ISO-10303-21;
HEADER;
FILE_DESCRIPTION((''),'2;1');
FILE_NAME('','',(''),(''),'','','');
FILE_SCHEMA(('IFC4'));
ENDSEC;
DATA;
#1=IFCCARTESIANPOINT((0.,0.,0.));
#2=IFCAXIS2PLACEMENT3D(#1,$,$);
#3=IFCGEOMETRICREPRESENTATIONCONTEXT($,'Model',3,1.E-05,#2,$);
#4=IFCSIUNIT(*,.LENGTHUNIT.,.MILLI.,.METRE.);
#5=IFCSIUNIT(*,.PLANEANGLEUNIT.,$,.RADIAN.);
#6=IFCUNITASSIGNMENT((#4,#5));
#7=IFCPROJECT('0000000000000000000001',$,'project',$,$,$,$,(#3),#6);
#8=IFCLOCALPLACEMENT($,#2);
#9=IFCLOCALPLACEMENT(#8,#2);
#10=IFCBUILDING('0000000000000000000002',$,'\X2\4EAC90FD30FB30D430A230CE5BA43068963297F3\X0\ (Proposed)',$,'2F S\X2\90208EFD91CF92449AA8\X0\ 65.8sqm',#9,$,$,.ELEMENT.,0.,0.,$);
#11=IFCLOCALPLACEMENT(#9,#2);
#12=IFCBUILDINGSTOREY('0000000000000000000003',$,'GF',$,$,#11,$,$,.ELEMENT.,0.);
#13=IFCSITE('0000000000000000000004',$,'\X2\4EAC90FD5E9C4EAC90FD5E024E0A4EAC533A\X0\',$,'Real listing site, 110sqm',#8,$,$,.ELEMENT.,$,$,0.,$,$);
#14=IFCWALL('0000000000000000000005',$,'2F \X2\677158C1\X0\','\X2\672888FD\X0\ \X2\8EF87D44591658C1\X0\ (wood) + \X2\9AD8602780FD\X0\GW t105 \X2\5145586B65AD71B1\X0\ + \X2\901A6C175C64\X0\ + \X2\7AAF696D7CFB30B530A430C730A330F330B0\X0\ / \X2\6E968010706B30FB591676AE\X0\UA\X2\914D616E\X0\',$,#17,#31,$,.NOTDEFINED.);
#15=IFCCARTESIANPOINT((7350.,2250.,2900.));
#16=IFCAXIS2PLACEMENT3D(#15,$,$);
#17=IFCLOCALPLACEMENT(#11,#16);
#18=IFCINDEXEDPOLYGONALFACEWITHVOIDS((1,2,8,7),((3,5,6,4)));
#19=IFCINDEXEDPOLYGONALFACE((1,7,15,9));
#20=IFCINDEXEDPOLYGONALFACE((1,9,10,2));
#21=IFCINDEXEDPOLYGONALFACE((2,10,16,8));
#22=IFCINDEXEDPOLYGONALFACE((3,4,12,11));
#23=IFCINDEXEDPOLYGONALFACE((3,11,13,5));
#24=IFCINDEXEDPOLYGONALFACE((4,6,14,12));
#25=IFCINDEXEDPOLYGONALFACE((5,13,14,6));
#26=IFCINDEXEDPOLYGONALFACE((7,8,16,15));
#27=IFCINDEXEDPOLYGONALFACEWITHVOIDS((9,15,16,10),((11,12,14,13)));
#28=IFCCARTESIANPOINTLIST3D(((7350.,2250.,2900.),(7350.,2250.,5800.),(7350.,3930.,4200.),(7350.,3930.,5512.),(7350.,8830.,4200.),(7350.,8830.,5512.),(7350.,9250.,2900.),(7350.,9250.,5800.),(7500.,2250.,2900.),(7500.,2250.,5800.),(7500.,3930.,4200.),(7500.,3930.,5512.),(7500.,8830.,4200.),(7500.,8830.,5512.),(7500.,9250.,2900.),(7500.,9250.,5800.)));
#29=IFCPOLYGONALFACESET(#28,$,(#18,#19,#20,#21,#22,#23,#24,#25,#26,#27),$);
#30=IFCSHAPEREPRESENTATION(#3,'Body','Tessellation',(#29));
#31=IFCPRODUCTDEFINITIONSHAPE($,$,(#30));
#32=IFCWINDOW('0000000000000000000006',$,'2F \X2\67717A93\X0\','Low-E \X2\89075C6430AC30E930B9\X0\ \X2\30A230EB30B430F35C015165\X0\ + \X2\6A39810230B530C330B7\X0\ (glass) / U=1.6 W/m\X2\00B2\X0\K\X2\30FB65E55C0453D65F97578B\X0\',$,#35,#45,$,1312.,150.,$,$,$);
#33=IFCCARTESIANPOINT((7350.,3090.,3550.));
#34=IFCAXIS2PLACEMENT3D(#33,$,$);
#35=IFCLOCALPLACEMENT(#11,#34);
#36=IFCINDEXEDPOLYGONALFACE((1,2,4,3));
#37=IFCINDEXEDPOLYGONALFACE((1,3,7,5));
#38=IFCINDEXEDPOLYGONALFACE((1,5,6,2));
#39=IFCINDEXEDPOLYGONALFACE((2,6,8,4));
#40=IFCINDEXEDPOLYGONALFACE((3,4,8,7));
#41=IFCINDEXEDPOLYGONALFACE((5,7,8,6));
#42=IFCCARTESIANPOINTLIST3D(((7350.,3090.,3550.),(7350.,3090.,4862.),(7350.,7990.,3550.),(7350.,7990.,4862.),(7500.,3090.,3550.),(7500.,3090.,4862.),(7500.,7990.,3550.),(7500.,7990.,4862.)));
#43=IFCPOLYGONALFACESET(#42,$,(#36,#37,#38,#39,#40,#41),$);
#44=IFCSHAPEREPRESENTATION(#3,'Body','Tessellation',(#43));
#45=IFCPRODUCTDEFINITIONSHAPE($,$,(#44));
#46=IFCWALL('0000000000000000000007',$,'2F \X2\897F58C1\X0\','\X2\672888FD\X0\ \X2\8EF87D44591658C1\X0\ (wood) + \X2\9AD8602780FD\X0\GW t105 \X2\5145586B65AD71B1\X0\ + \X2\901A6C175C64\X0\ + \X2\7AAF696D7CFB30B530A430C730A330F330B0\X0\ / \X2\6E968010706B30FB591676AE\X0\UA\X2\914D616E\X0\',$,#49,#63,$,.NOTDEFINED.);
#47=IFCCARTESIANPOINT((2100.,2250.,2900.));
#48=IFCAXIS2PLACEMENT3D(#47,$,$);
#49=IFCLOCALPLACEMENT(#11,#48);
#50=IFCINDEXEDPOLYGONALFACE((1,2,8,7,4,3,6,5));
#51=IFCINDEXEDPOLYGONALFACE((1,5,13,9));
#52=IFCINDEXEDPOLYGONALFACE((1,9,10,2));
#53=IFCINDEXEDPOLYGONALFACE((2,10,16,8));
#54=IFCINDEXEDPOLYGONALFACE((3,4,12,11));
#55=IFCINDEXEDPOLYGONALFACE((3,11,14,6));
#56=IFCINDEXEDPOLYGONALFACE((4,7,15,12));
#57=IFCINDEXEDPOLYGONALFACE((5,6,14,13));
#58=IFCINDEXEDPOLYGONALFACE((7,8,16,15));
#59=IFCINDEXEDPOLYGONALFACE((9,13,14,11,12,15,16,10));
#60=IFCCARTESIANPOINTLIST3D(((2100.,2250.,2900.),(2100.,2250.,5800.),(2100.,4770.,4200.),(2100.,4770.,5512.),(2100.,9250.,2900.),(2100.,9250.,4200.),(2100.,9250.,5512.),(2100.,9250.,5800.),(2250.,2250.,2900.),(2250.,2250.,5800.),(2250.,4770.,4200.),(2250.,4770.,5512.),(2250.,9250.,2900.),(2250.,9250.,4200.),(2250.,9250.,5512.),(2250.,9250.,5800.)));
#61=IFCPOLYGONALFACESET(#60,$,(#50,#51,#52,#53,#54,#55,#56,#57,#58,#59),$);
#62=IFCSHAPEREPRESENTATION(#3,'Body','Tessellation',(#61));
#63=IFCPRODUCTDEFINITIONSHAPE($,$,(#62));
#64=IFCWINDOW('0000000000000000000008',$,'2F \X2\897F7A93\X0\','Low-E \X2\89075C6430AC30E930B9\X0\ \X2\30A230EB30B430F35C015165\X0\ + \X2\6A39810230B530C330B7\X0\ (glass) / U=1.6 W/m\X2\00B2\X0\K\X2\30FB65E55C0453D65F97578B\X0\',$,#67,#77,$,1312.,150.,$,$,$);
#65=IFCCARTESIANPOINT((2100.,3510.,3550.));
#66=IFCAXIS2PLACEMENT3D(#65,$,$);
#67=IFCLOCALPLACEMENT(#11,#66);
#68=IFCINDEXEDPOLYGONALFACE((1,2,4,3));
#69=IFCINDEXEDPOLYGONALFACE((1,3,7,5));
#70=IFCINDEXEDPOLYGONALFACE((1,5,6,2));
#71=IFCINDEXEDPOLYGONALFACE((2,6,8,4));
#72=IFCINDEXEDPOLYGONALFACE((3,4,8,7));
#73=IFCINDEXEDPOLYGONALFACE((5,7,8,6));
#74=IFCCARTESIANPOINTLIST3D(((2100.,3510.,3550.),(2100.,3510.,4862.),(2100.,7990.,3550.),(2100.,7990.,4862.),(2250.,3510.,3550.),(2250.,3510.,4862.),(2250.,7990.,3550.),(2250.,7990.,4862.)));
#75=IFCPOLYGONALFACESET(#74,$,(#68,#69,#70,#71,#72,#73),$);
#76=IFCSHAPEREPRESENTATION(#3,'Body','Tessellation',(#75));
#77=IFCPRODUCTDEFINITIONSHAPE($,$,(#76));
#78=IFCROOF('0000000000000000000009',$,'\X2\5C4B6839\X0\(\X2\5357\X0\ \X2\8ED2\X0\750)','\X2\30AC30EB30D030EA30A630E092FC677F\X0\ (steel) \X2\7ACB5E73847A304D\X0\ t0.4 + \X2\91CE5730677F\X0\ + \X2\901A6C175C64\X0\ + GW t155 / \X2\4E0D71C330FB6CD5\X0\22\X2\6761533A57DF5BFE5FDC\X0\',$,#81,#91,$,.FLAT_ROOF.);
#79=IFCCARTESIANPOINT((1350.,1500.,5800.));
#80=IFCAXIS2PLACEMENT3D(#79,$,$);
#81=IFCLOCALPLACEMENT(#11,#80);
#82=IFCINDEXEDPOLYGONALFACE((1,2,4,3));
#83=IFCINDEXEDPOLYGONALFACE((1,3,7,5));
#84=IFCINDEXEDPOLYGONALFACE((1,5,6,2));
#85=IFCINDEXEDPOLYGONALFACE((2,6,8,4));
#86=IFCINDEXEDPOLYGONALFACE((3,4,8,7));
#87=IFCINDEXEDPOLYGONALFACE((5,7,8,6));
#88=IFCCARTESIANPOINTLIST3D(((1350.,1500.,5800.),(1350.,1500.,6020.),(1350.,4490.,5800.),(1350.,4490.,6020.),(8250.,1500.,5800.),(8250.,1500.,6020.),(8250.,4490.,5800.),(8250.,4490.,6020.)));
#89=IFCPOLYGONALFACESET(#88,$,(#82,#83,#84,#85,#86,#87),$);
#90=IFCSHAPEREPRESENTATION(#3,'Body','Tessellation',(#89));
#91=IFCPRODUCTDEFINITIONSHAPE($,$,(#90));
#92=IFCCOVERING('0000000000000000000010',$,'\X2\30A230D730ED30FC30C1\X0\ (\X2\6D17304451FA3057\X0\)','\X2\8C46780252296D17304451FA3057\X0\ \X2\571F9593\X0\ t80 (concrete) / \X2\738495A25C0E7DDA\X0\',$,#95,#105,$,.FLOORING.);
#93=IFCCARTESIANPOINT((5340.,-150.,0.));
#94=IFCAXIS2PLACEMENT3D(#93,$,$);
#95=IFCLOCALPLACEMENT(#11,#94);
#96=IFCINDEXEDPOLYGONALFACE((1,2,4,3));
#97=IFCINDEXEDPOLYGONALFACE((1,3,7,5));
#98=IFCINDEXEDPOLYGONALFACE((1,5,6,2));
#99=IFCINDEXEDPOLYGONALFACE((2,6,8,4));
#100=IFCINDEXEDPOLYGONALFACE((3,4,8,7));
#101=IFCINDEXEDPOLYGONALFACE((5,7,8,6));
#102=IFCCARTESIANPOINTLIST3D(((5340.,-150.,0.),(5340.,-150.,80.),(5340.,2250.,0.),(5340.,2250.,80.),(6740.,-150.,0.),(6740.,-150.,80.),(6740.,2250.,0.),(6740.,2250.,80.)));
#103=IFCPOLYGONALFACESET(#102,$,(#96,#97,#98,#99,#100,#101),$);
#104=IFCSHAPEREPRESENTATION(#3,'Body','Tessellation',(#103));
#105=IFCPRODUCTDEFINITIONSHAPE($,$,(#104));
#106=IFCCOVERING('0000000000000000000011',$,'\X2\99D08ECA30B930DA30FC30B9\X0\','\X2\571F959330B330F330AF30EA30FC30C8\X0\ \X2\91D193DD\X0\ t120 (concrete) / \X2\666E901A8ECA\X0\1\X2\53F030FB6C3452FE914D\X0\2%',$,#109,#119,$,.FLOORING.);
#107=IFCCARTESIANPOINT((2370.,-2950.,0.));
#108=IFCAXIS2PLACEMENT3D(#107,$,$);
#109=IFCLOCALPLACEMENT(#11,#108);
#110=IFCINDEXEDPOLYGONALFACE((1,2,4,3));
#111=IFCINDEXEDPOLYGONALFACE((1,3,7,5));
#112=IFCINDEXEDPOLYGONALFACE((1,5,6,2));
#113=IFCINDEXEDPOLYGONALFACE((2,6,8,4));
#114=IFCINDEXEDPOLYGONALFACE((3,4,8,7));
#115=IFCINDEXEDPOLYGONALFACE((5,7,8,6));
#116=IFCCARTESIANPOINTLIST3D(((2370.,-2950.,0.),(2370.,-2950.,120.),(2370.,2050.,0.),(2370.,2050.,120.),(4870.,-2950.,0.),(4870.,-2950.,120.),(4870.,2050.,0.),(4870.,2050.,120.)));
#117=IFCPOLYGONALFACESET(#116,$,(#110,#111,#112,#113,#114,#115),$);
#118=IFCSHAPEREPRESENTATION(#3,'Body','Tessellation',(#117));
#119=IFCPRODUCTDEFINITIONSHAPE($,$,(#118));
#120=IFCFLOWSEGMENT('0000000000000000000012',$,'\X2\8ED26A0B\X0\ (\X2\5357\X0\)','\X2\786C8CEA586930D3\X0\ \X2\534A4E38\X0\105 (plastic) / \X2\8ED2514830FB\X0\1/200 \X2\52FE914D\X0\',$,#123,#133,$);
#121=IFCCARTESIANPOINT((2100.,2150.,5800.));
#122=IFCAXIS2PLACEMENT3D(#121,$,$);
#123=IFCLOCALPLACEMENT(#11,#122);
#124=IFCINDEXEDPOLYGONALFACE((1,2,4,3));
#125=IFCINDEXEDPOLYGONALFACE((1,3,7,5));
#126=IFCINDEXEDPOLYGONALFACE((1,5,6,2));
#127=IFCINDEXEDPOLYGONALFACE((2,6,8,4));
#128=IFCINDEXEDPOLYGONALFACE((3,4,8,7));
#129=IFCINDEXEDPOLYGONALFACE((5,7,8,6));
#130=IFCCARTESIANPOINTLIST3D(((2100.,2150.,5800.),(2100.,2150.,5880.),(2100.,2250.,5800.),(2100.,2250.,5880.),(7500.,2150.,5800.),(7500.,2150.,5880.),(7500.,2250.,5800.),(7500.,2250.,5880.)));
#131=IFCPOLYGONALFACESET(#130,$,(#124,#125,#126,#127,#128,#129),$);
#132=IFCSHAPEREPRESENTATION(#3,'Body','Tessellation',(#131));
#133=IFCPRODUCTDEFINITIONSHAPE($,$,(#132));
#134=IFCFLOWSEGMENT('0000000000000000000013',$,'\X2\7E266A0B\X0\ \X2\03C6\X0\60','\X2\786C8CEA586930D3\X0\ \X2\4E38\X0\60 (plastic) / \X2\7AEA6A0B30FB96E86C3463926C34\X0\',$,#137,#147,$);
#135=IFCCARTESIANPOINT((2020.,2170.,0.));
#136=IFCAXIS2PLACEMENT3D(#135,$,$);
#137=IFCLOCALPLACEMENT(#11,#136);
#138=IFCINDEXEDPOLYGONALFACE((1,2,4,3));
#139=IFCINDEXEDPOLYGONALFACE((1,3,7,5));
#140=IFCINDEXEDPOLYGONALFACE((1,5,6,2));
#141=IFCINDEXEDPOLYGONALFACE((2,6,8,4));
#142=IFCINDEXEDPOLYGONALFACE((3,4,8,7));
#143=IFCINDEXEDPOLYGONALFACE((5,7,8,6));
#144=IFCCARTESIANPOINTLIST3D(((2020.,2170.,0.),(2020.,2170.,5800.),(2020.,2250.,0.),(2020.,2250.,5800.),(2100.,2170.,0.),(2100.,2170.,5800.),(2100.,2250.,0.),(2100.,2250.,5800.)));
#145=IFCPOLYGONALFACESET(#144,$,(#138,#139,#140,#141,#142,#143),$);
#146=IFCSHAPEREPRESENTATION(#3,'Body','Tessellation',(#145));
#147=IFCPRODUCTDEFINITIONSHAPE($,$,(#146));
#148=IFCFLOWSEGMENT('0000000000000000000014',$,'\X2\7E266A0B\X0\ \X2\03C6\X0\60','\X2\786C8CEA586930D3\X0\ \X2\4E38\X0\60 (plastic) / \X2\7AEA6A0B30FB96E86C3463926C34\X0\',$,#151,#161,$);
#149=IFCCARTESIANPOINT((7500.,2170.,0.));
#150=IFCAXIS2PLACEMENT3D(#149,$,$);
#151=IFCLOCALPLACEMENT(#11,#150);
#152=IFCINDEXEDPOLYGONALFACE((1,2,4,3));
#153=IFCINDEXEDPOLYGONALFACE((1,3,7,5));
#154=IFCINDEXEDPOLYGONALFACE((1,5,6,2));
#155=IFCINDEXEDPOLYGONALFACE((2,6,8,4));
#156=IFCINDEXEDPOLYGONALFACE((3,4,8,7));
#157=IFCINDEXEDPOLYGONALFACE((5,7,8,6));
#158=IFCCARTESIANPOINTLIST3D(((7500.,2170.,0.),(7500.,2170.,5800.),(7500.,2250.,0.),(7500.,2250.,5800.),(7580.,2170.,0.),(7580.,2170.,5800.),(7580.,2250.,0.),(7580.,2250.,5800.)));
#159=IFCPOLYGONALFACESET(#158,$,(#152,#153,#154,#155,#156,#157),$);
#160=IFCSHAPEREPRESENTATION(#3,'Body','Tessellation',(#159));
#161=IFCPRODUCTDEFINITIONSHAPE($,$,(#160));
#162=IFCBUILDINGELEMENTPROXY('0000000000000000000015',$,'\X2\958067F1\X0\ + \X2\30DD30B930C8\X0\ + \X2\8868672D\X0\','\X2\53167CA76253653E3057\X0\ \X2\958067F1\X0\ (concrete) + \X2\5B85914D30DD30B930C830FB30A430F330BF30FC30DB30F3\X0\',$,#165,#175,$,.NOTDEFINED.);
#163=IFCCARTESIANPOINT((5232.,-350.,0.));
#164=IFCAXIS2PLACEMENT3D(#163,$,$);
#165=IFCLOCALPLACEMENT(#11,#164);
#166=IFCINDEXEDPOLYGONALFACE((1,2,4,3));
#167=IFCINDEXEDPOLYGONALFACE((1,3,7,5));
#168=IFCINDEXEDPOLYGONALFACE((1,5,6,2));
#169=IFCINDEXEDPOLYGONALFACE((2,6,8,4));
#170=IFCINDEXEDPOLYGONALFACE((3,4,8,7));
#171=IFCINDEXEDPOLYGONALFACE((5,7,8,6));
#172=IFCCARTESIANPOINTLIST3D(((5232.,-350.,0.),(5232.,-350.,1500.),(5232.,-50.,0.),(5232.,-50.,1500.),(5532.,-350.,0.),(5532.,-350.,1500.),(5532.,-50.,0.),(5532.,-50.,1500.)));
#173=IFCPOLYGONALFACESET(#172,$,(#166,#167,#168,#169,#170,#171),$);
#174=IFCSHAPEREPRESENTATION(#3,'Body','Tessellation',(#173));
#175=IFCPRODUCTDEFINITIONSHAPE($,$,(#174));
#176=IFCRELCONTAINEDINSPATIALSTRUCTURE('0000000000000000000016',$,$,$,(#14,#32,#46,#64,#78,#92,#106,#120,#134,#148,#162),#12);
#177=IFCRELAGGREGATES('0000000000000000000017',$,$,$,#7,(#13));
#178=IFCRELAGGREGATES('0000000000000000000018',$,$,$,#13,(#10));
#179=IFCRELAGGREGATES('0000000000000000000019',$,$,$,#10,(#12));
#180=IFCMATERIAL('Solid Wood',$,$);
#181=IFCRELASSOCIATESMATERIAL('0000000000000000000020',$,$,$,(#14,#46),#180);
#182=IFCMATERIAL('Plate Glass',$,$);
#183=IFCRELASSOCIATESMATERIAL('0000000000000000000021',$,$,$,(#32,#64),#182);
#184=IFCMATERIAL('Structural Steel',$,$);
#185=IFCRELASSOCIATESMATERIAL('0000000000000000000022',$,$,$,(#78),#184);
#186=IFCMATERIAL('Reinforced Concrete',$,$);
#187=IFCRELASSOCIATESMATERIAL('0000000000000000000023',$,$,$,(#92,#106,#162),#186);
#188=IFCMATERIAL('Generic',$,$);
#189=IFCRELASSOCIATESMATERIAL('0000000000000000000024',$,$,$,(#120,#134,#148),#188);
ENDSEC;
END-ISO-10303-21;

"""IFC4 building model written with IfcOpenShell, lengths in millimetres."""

from ifc_helpers import new_model, si_unit, frame, frame_2d, origin, place, context, project, spatial, rectangle, extrude, material, element, fill, save


model = new_model("IFC4")

# Units and contexts
model_context = context("Model", 3, precision=1e-05, world=origin())
ifc_project = project(units=[si_unit("LENGTHUNIT", "METRE", prefix="MILLI"), si_unit("PLANEANGLEUNIT", "RADIAN")], contexts=[model_context])

# Site, building, storey
site_placement = place(None, origin())
site = spatial("IfcSite", under=ifc_project, at=site_placement, Name="京都府京都市上京区", ObjectType="Real listing site, 110sqm", CompositionType="ELEMENT", RefElevation=0.0)
building_placement = place(site_placement, origin())
building = spatial("IfcBuilding", under=site, at=building_placement, Name="京都・ピアノ室と防音 (Proposed)", ObjectType="2F S造軽量鉄骨 65.8sqm", CompositionType="ELEMENT", ElevationOfRefHeight=0.0, ElevationOfTerrain=0.0)
storey_placement = place(building_placement, origin())
storey = spatial("IfcBuildingStorey", under=building, at=storey_placement, Name="GF", CompositionType="ELEMENT", Elevation=0.0)

# Shared definitions
ifc_material_1 = material(Name="Solid Wood")

# Shared definitions
ifc_material_2 = material(Name="Reinforced Concrete")

# Shared definitions
ifc_material_3 = material(Name="Plate Glass")

# Walls, openings, windows
wall_1_placement = place(storey_placement, frame((7350.0, 2250.0, 2900.0)))
wall_1 = element("IfcWall", 1, at=wall_1_placement, inside=storey, material=ifc_material_1, Name="2F 東壁", Description="木製 軸組外壁 (wood) + 高性能GW t105 充填断熱 + 通気層 + 窯業系サイディング / 準耐火・外皮UA配慮", PredefinedType="NOTDEFINED", context=model_context, shape_type="SweptSolid", body=[
    extrude(rectangle(XDim=150.0, YDim=7000.0, at=frame_2d((75.0, 3500.0))), frame((7350.0, 2250.0, 2900.0)), (0.0, 0.0, 1.0), 2900.0),
])
opening_1_placement = place(storey_placement, frame((7350.0, 3090.0, 3550.0)))
opening_1 = element("IfcOpeningElement", 2, at=opening_1_placement, cuts=wall_1, PredefinedType="NOTDEFINED", context=model_context, shape_type="SweptSolid", body=[
    extrude(rectangle(XDim=150.0, YDim=4900.0, at=frame_2d((75.0, 2450.0))), frame((7350.0, 3090.0, 3550.0)), (0.0, 0.0, 1.0), 1312.0),
])
window_1_placement = place(storey_placement, frame((7350.0, 3090.0, 3550.0)))
window_1 = element("IfcWindow", 3, at=window_1_placement, inside=storey, material=ifc_material_3, Name="2F 東窓", Description="Low-E 複層ガラス アルゴン封入 + 樹脂サッシ (glass) / U=1.6 W/m²K・日射取得型", OverallHeight=1312.0, OverallWidth=150.0, context=model_context, shape_type="SweptSolid", body=[
    extrude(rectangle(XDim=150.0, YDim=4900.0, at=frame_2d((75.0, 2450.0))), frame((7350.0, 3090.0, 3550.0)), (0.0, 0.0, 1.0), 1312.0),
])
fill(opening_1, window_1)
wall_2_placement = place(storey_placement, frame((2100.0, 2250.0, 2900.0)))
wall_2 = element("IfcWall", 4, at=wall_2_placement, inside=storey, material=ifc_material_1, Name="2F 西壁", Description="木製 軸組外壁 (wood) + 高性能GW t105 充填断熱 + 通気層 + 窯業系サイディング / 準耐火・外皮UA配慮", PredefinedType="NOTDEFINED", context=model_context, shape_type="SweptSolid", body=[
    extrude(rectangle(XDim=150.0, YDim=7000.0, at=frame_2d((75.0, 3500.0))), frame((2100.0, 2250.0, 2900.0)), (0.0, 0.0, 1.0), 2900.0),
])
opening_2_placement = place(storey_placement, frame((2100.0, 3510.0, 3550.0)))
opening_2 = element("IfcOpeningElement", 5, at=opening_2_placement, cuts=wall_2, PredefinedType="NOTDEFINED", context=model_context, shape_type="SweptSolid", body=[
    extrude(rectangle(XDim=150.0, YDim=4480.0, at=frame_2d((75.0, 2240.0))), frame((2100.0, 3510.0, 3550.0)), (0.0, 0.0, 1.0), 1312.0),
])
window_2_placement = place(storey_placement, frame((2100.0, 3510.0, 3550.0)))
window_2 = element("IfcWindow", 6, at=window_2_placement, inside=storey, material=ifc_material_3, Name="2F 西窓", Description="Low-E 複層ガラス アルゴン封入 + 樹脂サッシ (glass) / U=1.6 W/m²K・日射取得型", OverallHeight=1312.0, OverallWidth=150.0, context=model_context, shape_type="SweptSolid", body=[
    extrude(rectangle(XDim=150.0, YDim=4480.0, at=frame_2d((75.0, 2240.0))), frame((2100.0, 3510.0, 3550.0)), (0.0, 0.0, 1.0), 1312.0),
])
fill(opening_2, window_2)

# Roof
ifc_material_4 = material(Name="Structural Steel")
for number, where, name in (
    (7, (1350.0, 1500.0, 5800.0), "屋根(南 軒750)"),
):
    element("IfcRoof", number, at=place(storey_placement, frame(where)), inside=storey, material=ifc_material_4, Name=name, Description="ガルバリウム鋼板 (steel) 立平葺き t0.4 + 野地板 + 通気層 + GW t155 / 不燃・法22条区域対応", PredefinedType="FLAT_ROOF", context=model_context, shape_type="SweptSolid", body=[
        extrude(rectangle(XDim=6900.0, YDim=2990.0, at=frame_2d((3450.0, 1495.0))), frame((1350.0, 1500.0, 5800.0)), (0.0, 0.0, 1.0), 220.0),
    ])

# Coverings
covering_1_placement = place(storey_placement, frame((5340.0, -150.0, 0.0)))
element("IfcCovering", 8, at=covering_1_placement, inside=storey, material=ifc_material_2, Name="アプローチ (洗い出し)", Description="豆砂利洗い出し 土間 t80 (concrete) / 玄関導線", PredefinedType="FLOORING", context=model_context, shape_type="SweptSolid", body=[
    extrude(rectangle(XDim=1400.0, YDim=2400.0, at=frame_2d((700.0, 1200.0))), frame((5340.0, -150.0, 0.0)), (0.0, 0.0, 1.0), 80.0),
])
covering_2_placement = place(storey_placement, frame((2370.0, -2950.0, 0.0)))
element("IfcCovering", 9, at=covering_2_placement, inside=storey, material=ifc_material_2, Name="駐車スペース", Description="土間コンクリート 金鏝 t120 (concrete) / 普通車1台・水勾配2%", PredefinedType="FLOORING", context=model_context, shape_type="SweptSolid", body=[
    extrude(rectangle(XDim=2500.0, YDim=5000.0, at=frame_2d((1250.0, 2500.0))), frame((2370.0, -2950.0, 0.0)), (0.0, 0.0, 1.0), 120.0),
])

# Flow segments
ifc_material_5 = material(Name="Generic")
flow_segment_1_placement = place(storey_placement, frame((2100.0, 2150.0, 5800.0)))
element("IfcFlowSegment", 10, at=flow_segment_1_placement, inside=storey, material=ifc_material_5, Name="軒樋 (南)", Description="硬質塩ビ 半丸105 (plastic) / 軒先・1/200 勾配", context=model_context, shape_type="SweptSolid", body=[
    extrude(rectangle(XDim=5400.0, YDim=100.0, at=frame_2d((2700.0, 50.0))), frame((2100.0, 2150.0, 5800.0)), (0.0, 0.0, 1.0), 80.0),
])
flow_segment_2_placement = place(storey_placement, frame((2020.0, 2170.0, 0.0)))
element("IfcFlowSegment", 11, at=flow_segment_2_placement, inside=storey, material=ifc_material_5, Name="縦樋 φ60", Description="硬質塩ビ 丸60 (plastic) / 竪樋・雨水排水", context=model_context, shape_type="SweptSolid", body=[
    extrude(rectangle(XDim=80.0, YDim=80.0, at=frame_2d((40.0, 40.0))), frame((2020.0, 2170.0, 0.0)), (0.0, 0.0, 1.0), 5800.0),
])
flow_segment_3_placement = place(storey_placement, frame((7500.0, 2170.0, 0.0)))
element("IfcFlowSegment", 12, at=flow_segment_3_placement, inside=storey, material=ifc_material_5, Name="縦樋 φ60", Description="硬質塩ビ 丸60 (plastic) / 竪樋・雨水排水", context=model_context, shape_type="SweptSolid", body=[
    extrude(rectangle(XDim=80.0, YDim=80.0, at=frame_2d((40.0, 40.0))), frame((7500.0, 2170.0, 0.0)), (0.0, 0.0, 1.0), 5800.0),
])

# Building element proxy
proxy_placement = place(storey_placement, frame((5232.0, -350.0, 0.0)))
element("IfcBuildingElementProxy", 13, at=proxy_placement, inside=storey, material=ifc_material_2, Name="門柱 + ポスト + 表札", Description="化粧打放し 門柱 (concrete) + 宅配ポスト・インターホン", PredefinedType="NOTDEFINED", context=model_context, shape_type="SweptSolid", body=[
    extrude(rectangle(XDim=300.0, YDim=300.0, at=frame_2d((150.0, 150.0))), frame((5232.0, -350.0, 0.0)), (0.0, 0.0, 1.0), 1500.0),
])

save(model, "model.ifc")
